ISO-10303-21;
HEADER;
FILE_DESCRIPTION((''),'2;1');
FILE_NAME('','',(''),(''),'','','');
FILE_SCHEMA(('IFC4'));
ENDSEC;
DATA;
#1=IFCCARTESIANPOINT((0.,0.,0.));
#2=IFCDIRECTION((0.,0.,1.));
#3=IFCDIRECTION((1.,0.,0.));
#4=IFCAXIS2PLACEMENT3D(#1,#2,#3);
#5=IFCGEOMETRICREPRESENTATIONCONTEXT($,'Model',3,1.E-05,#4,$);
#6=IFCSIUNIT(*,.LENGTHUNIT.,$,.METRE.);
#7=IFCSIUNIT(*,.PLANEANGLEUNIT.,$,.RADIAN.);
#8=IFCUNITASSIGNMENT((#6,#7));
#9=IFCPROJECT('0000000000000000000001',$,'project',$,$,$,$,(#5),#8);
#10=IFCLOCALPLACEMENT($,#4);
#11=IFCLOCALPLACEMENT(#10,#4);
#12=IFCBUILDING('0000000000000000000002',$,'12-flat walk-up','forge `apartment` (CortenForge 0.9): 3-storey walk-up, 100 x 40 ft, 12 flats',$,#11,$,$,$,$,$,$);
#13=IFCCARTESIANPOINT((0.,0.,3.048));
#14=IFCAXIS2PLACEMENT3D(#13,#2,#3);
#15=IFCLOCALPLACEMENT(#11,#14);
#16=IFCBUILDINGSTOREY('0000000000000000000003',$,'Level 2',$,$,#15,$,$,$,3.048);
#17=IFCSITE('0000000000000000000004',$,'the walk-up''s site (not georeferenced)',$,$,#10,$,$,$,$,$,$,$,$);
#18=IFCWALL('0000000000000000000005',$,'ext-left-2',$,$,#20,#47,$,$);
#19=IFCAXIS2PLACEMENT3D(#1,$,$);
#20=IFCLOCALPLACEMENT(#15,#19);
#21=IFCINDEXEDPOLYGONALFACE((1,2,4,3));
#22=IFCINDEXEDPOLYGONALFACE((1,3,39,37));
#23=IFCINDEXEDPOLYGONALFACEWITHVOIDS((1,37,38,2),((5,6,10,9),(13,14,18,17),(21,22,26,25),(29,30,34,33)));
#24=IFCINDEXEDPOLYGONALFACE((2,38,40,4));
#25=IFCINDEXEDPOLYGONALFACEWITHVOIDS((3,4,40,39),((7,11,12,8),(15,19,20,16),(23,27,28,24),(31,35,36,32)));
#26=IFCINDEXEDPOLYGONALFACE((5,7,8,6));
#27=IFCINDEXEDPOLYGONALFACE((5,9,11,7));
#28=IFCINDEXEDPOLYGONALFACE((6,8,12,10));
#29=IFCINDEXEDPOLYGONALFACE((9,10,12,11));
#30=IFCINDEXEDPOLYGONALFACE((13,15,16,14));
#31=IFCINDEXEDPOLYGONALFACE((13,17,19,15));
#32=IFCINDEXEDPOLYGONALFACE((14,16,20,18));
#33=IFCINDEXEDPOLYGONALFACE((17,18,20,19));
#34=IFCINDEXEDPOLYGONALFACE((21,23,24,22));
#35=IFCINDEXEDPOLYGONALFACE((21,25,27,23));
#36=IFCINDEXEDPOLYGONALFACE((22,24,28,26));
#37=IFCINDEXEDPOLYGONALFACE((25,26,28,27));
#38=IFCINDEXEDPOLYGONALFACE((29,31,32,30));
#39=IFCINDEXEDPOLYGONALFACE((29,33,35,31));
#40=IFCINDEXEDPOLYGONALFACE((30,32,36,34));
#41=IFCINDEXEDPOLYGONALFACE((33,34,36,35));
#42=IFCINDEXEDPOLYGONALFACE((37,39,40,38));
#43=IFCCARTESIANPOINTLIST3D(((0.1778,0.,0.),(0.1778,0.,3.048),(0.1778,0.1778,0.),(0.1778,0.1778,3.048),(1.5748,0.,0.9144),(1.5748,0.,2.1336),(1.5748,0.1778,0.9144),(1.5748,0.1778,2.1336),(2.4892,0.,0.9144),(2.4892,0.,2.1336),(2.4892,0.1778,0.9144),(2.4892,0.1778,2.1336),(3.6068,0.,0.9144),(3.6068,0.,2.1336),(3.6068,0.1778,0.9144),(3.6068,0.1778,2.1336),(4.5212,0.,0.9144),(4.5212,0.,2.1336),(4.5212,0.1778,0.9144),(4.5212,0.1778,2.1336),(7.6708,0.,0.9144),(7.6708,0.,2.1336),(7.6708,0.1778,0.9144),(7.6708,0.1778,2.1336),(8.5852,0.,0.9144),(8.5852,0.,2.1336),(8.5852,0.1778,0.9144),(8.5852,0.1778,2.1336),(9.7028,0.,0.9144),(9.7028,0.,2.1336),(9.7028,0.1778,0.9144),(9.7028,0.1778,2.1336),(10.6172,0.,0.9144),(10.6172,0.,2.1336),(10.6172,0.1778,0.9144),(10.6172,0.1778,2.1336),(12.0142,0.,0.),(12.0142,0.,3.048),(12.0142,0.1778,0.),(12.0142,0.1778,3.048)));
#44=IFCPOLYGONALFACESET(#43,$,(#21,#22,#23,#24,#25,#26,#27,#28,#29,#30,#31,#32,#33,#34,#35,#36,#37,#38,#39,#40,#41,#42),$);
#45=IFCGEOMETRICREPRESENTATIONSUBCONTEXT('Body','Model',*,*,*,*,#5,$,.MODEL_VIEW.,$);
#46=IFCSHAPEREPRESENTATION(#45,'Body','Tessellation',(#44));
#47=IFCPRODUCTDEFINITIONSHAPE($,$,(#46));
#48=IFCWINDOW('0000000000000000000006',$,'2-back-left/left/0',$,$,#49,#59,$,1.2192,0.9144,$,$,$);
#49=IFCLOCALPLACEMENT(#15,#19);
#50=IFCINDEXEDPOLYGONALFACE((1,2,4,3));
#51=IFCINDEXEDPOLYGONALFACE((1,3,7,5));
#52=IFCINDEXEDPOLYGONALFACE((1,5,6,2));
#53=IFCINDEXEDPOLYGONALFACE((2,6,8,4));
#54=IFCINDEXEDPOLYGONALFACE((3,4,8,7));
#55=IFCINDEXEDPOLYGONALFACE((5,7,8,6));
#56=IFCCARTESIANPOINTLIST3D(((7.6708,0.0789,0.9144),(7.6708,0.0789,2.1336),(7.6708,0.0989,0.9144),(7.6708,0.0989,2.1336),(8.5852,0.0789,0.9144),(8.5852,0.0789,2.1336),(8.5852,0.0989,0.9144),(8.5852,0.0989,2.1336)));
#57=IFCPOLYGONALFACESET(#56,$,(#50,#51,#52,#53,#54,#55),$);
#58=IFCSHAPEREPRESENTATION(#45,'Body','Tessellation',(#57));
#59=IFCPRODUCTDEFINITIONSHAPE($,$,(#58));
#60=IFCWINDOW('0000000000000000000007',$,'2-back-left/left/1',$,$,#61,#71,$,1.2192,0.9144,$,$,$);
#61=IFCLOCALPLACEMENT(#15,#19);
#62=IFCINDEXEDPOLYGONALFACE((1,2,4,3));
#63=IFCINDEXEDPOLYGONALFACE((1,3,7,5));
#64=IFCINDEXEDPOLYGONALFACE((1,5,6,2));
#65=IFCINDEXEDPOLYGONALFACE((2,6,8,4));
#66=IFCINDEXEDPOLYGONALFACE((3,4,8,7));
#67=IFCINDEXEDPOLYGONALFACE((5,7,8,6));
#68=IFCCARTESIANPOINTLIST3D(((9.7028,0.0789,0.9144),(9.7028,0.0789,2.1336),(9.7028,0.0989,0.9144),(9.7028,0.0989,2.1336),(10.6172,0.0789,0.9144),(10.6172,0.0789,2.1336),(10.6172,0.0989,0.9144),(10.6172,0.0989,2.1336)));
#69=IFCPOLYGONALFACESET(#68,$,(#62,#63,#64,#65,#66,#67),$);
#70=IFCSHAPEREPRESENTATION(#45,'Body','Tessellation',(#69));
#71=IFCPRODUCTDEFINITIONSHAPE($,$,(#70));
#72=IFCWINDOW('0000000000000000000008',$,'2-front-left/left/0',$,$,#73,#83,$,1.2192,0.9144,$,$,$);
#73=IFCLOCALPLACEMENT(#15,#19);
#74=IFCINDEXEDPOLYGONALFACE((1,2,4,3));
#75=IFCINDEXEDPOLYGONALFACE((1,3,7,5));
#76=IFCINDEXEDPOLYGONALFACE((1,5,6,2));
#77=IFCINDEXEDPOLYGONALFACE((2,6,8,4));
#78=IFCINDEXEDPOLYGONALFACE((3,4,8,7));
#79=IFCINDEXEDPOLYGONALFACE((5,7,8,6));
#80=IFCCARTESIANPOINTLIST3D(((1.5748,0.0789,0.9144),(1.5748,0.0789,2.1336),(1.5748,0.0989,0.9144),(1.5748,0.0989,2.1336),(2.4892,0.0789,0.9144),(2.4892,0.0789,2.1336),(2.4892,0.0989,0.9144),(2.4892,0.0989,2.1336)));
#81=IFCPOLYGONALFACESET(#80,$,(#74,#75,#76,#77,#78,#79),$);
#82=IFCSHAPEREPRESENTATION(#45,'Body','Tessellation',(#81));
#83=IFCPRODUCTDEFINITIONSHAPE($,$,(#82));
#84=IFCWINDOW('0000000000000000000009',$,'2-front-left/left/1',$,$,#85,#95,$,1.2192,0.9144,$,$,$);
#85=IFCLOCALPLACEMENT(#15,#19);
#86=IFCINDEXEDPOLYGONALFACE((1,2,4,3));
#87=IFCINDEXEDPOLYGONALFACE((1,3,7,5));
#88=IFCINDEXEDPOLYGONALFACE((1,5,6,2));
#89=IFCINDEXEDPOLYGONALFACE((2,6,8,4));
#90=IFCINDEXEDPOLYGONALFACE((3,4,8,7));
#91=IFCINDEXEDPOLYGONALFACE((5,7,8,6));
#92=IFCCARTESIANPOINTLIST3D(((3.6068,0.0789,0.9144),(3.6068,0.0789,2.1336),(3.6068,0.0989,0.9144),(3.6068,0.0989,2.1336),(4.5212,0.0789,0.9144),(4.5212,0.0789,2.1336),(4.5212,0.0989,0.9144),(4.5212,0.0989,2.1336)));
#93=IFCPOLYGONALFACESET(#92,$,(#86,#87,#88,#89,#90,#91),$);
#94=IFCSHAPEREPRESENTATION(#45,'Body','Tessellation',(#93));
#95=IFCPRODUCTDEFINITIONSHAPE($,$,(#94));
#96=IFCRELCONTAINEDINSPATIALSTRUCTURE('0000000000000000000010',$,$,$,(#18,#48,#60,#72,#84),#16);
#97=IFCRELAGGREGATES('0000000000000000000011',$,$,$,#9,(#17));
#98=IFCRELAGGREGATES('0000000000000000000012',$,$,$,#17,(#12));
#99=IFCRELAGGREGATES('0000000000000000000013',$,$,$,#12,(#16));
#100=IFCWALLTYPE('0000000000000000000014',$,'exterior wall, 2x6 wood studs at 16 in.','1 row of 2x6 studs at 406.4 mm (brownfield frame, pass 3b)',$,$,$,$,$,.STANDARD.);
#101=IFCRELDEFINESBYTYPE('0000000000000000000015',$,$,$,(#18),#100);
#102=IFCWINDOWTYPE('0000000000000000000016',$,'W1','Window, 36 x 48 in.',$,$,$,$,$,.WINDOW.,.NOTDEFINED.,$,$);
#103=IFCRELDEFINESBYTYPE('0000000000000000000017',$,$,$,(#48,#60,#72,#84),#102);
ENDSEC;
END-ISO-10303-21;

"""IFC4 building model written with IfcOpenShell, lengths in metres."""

from ifc_helpers import new_model, si_unit, frame, frame_2d, origin, origin_with_axes, place, context, subcontext, project, spatial, rectangle, extrude, type_object, element, fill, save


model = new_model("IFC4")

# Units and contexts
model_context = context("Model", 3, precision=1e-05, world=origin_with_axes())
body_context = subcontext(model_context, "Body", "Model", "MODEL_VIEW")
ifc_project = project(units=[si_unit("LENGTHUNIT", "METRE"), si_unit("PLANEANGLEUNIT", "RADIAN")], contexts=[model_context])

# Site, building, storey
site_placement = place(None, origin_with_axes())
site = spatial("IfcSite", under=ifc_project, at=site_placement, Name="the walk-up's site (not georeferenced)")
building_placement = place(site_placement, origin_with_axes())
building = spatial("IfcBuilding", under=site, at=building_placement, Name="12-flat walk-up", Description="forge `apartment` (CortenForge 0.9): 3-storey walk-up, 100 x 40 ft, 12 flats")
storey_placement = place(building_placement, frame((0.0, 0.0, 3.048), z_axis=(0.0, 0.0, 1.0), x_axis=(1.0, 0.0, 0.0)))
storey = spatial("IfcBuildingStorey", under=building, at=storey_placement, Name="Level 2", Elevation=3.048)

# Shared definitions
wall_type = type_object("IfcWallType", Name="exterior wall, 2x6 wood studs at 16 in.", Description="1 row of 2x6 studs at 406.4 mm (brownfield frame, pass 3b)", PredefinedType="STANDARD")
window_type_1 = type_object("IfcWindowType", Name="W1", Description="Window, 36 x 48 in.", PartitioningType="NOTDEFINED", PredefinedType="WINDOW")

# Wall, openings, windows
wall_1_placement = place(storey_placement, frame((0.1778, 0.0, 0.0), z_axis=(0.0, 0.0, 1.0), x_axis=(1.0, 0.0, 0.0)))
wall_1 = element("IfcWall", 1, at=wall_1_placement, inside=storey, type_object=wall_type, Name="ext-left-2", context=body_context, shape_type="SweptSolid", body=[
    extrude(rectangle(XDim=11.8364, YDim=0.1778, at=frame_2d((5.9182, 0.0889))), origin(), (0.0, 0.0, 1.0), 3.048),
])
opening_1_placement = place(wall_1_placement, frame((7.493, 0.0, 0.9144), z_axis=(0.0, 0.0, 1.0), x_axis=(1.0, 0.0, 0.0)))
opening_1 = element("IfcOpeningElement", 2, at=opening_1_placement, cuts=wall_1, PredefinedType="OPENING", context=body_context, shape_type="SweptSolid", body=[
    extrude(rectangle(XDim=0.9144, YDim=0.1778, at=frame_2d((0.4572, 0.0889))), origin(), (0.0, 0.0, 1.0), 1.2192),
])
opening_2_placement = place(wall_1_placement, frame((9.525, 0.0, 0.9144), z_axis=(0.0, 0.0, 1.0), x_axis=(1.0, 0.0, 0.0)))
opening_2 = element("IfcOpeningElement", 3, at=opening_2_placement, cuts=wall_1, PredefinedType="OPENING", context=body_context, shape_type="SweptSolid", body=[
    extrude(rectangle(XDim=0.9144, YDim=0.1778, at=frame_2d((0.4572, 0.0889))), origin(), (0.0, 0.0, 1.0), 1.2192),
])
opening_3_placement = place(wall_1_placement, frame((1.397, 0.0, 0.9144), z_axis=(0.0, 0.0, 1.0), x_axis=(1.0, 0.0, 0.0)))
opening_3 = element("IfcOpeningElement", 4, at=opening_3_placement, cuts=wall_1, PredefinedType="OPENING", context=body_context, shape_type="SweptSolid", body=[
    extrude(rectangle(XDim=0.9144, YDim=0.1778, at=frame_2d((0.4572, 0.0889))), origin(), (0.0, 0.0, 1.0), 1.2192),
])
opening_4_placement = place(wall_1_placement, frame((3.429, 0.0, 0.9144), z_axis=(0.0, 0.0, 1.0), x_axis=(1.0, 0.0, 0.0)))
opening_4 = element("IfcOpeningElement", 5, at=opening_4_placement, cuts=wall_1, PredefinedType="OPENING", context=body_context, shape_type="SweptSolid", body=[
    extrude(rectangle(XDim=0.9144, YDim=0.1778, at=frame_2d((0.4572, 0.0889))), origin(), (0.0, 0.0, 1.0), 1.2192),
])
window_1_placement = place(opening_1_placement, frame((0.0, 0.0789, 0.0), z_axis=(0.0, 0.0, 1.0), x_axis=(1.0, 0.0, 0.0)))
window_1 = element("IfcWindow", 6, at=window_1_placement, inside=storey, type_object=window_type_1, Name="2-back-left/left/0", OverallHeight=1.2192, OverallWidth=0.9144, context=body_context, shape_type="SweptSolid", body=[
    extrude(rectangle(XDim=0.9144, YDim=0.02, at=frame_2d((0.4572, 0.01))), origin(), (0.0, 0.0, 1.0), 1.2192),
])
fill(opening_1, window_1)
window_2_placement = place(opening_2_placement, frame((0.0, 0.0789, 0.0), z_axis=(0.0, 0.0, 1.0), x_axis=(1.0, 0.0, 0.0)))
window_2 = element("IfcWindow", 7, at=window_2_placement, inside=storey, type_object=window_type_1, Name="2-back-left/left/1", OverallHeight=1.2192, OverallWidth=0.9144, context=body_context, shape_type="SweptSolid", body=[
    extrude(rectangle(XDim=0.9144, YDim=0.02, at=frame_2d((0.4572, 0.01))), origin(), (0.0, 0.0, 1.0), 1.2192),
])
fill(opening_2, window_2)
window_3_placement = place(opening_3_placement, frame((0.0, 0.0789, 0.0), z_axis=(0.0, 0.0, 1.0), x_axis=(1.0, 0.0, 0.0)))
window_3 = element("IfcWindow", 8, at=window_3_placement, inside=storey, type_object=window_type_1, Name="2-front-left/left/0", OverallHeight=1.2192, OverallWidth=0.9144, context=body_context, shape_type="SweptSolid", body=[
    extrude(rectangle(XDim=0.9144, YDim=0.02, at=frame_2d((0.4572, 0.01))), origin(), (0.0, 0.0, 1.0), 1.2192),
])
fill(opening_3, window_3)
window_4_placement = place(opening_4_placement, frame((0.0, 0.0789, 0.0), z_axis=(0.0, 0.0, 1.0), x_axis=(1.0, 0.0, 0.0)))
window_4 = element("IfcWindow", 9, at=window_4_placement, inside=storey, type_object=window_type_1, Name="2-front-left/left/1", OverallHeight=1.2192, OverallWidth=0.9144, context=body_context, shape_type="SweptSolid", body=[
    extrude(rectangle(XDim=0.9144, YDim=0.02, at=frame_2d((0.4572, 0.01))), origin(), (0.0, 0.0, 1.0), 1.2192),
])
fill(opening_4, window_4)

save(model, "model.ifc")
